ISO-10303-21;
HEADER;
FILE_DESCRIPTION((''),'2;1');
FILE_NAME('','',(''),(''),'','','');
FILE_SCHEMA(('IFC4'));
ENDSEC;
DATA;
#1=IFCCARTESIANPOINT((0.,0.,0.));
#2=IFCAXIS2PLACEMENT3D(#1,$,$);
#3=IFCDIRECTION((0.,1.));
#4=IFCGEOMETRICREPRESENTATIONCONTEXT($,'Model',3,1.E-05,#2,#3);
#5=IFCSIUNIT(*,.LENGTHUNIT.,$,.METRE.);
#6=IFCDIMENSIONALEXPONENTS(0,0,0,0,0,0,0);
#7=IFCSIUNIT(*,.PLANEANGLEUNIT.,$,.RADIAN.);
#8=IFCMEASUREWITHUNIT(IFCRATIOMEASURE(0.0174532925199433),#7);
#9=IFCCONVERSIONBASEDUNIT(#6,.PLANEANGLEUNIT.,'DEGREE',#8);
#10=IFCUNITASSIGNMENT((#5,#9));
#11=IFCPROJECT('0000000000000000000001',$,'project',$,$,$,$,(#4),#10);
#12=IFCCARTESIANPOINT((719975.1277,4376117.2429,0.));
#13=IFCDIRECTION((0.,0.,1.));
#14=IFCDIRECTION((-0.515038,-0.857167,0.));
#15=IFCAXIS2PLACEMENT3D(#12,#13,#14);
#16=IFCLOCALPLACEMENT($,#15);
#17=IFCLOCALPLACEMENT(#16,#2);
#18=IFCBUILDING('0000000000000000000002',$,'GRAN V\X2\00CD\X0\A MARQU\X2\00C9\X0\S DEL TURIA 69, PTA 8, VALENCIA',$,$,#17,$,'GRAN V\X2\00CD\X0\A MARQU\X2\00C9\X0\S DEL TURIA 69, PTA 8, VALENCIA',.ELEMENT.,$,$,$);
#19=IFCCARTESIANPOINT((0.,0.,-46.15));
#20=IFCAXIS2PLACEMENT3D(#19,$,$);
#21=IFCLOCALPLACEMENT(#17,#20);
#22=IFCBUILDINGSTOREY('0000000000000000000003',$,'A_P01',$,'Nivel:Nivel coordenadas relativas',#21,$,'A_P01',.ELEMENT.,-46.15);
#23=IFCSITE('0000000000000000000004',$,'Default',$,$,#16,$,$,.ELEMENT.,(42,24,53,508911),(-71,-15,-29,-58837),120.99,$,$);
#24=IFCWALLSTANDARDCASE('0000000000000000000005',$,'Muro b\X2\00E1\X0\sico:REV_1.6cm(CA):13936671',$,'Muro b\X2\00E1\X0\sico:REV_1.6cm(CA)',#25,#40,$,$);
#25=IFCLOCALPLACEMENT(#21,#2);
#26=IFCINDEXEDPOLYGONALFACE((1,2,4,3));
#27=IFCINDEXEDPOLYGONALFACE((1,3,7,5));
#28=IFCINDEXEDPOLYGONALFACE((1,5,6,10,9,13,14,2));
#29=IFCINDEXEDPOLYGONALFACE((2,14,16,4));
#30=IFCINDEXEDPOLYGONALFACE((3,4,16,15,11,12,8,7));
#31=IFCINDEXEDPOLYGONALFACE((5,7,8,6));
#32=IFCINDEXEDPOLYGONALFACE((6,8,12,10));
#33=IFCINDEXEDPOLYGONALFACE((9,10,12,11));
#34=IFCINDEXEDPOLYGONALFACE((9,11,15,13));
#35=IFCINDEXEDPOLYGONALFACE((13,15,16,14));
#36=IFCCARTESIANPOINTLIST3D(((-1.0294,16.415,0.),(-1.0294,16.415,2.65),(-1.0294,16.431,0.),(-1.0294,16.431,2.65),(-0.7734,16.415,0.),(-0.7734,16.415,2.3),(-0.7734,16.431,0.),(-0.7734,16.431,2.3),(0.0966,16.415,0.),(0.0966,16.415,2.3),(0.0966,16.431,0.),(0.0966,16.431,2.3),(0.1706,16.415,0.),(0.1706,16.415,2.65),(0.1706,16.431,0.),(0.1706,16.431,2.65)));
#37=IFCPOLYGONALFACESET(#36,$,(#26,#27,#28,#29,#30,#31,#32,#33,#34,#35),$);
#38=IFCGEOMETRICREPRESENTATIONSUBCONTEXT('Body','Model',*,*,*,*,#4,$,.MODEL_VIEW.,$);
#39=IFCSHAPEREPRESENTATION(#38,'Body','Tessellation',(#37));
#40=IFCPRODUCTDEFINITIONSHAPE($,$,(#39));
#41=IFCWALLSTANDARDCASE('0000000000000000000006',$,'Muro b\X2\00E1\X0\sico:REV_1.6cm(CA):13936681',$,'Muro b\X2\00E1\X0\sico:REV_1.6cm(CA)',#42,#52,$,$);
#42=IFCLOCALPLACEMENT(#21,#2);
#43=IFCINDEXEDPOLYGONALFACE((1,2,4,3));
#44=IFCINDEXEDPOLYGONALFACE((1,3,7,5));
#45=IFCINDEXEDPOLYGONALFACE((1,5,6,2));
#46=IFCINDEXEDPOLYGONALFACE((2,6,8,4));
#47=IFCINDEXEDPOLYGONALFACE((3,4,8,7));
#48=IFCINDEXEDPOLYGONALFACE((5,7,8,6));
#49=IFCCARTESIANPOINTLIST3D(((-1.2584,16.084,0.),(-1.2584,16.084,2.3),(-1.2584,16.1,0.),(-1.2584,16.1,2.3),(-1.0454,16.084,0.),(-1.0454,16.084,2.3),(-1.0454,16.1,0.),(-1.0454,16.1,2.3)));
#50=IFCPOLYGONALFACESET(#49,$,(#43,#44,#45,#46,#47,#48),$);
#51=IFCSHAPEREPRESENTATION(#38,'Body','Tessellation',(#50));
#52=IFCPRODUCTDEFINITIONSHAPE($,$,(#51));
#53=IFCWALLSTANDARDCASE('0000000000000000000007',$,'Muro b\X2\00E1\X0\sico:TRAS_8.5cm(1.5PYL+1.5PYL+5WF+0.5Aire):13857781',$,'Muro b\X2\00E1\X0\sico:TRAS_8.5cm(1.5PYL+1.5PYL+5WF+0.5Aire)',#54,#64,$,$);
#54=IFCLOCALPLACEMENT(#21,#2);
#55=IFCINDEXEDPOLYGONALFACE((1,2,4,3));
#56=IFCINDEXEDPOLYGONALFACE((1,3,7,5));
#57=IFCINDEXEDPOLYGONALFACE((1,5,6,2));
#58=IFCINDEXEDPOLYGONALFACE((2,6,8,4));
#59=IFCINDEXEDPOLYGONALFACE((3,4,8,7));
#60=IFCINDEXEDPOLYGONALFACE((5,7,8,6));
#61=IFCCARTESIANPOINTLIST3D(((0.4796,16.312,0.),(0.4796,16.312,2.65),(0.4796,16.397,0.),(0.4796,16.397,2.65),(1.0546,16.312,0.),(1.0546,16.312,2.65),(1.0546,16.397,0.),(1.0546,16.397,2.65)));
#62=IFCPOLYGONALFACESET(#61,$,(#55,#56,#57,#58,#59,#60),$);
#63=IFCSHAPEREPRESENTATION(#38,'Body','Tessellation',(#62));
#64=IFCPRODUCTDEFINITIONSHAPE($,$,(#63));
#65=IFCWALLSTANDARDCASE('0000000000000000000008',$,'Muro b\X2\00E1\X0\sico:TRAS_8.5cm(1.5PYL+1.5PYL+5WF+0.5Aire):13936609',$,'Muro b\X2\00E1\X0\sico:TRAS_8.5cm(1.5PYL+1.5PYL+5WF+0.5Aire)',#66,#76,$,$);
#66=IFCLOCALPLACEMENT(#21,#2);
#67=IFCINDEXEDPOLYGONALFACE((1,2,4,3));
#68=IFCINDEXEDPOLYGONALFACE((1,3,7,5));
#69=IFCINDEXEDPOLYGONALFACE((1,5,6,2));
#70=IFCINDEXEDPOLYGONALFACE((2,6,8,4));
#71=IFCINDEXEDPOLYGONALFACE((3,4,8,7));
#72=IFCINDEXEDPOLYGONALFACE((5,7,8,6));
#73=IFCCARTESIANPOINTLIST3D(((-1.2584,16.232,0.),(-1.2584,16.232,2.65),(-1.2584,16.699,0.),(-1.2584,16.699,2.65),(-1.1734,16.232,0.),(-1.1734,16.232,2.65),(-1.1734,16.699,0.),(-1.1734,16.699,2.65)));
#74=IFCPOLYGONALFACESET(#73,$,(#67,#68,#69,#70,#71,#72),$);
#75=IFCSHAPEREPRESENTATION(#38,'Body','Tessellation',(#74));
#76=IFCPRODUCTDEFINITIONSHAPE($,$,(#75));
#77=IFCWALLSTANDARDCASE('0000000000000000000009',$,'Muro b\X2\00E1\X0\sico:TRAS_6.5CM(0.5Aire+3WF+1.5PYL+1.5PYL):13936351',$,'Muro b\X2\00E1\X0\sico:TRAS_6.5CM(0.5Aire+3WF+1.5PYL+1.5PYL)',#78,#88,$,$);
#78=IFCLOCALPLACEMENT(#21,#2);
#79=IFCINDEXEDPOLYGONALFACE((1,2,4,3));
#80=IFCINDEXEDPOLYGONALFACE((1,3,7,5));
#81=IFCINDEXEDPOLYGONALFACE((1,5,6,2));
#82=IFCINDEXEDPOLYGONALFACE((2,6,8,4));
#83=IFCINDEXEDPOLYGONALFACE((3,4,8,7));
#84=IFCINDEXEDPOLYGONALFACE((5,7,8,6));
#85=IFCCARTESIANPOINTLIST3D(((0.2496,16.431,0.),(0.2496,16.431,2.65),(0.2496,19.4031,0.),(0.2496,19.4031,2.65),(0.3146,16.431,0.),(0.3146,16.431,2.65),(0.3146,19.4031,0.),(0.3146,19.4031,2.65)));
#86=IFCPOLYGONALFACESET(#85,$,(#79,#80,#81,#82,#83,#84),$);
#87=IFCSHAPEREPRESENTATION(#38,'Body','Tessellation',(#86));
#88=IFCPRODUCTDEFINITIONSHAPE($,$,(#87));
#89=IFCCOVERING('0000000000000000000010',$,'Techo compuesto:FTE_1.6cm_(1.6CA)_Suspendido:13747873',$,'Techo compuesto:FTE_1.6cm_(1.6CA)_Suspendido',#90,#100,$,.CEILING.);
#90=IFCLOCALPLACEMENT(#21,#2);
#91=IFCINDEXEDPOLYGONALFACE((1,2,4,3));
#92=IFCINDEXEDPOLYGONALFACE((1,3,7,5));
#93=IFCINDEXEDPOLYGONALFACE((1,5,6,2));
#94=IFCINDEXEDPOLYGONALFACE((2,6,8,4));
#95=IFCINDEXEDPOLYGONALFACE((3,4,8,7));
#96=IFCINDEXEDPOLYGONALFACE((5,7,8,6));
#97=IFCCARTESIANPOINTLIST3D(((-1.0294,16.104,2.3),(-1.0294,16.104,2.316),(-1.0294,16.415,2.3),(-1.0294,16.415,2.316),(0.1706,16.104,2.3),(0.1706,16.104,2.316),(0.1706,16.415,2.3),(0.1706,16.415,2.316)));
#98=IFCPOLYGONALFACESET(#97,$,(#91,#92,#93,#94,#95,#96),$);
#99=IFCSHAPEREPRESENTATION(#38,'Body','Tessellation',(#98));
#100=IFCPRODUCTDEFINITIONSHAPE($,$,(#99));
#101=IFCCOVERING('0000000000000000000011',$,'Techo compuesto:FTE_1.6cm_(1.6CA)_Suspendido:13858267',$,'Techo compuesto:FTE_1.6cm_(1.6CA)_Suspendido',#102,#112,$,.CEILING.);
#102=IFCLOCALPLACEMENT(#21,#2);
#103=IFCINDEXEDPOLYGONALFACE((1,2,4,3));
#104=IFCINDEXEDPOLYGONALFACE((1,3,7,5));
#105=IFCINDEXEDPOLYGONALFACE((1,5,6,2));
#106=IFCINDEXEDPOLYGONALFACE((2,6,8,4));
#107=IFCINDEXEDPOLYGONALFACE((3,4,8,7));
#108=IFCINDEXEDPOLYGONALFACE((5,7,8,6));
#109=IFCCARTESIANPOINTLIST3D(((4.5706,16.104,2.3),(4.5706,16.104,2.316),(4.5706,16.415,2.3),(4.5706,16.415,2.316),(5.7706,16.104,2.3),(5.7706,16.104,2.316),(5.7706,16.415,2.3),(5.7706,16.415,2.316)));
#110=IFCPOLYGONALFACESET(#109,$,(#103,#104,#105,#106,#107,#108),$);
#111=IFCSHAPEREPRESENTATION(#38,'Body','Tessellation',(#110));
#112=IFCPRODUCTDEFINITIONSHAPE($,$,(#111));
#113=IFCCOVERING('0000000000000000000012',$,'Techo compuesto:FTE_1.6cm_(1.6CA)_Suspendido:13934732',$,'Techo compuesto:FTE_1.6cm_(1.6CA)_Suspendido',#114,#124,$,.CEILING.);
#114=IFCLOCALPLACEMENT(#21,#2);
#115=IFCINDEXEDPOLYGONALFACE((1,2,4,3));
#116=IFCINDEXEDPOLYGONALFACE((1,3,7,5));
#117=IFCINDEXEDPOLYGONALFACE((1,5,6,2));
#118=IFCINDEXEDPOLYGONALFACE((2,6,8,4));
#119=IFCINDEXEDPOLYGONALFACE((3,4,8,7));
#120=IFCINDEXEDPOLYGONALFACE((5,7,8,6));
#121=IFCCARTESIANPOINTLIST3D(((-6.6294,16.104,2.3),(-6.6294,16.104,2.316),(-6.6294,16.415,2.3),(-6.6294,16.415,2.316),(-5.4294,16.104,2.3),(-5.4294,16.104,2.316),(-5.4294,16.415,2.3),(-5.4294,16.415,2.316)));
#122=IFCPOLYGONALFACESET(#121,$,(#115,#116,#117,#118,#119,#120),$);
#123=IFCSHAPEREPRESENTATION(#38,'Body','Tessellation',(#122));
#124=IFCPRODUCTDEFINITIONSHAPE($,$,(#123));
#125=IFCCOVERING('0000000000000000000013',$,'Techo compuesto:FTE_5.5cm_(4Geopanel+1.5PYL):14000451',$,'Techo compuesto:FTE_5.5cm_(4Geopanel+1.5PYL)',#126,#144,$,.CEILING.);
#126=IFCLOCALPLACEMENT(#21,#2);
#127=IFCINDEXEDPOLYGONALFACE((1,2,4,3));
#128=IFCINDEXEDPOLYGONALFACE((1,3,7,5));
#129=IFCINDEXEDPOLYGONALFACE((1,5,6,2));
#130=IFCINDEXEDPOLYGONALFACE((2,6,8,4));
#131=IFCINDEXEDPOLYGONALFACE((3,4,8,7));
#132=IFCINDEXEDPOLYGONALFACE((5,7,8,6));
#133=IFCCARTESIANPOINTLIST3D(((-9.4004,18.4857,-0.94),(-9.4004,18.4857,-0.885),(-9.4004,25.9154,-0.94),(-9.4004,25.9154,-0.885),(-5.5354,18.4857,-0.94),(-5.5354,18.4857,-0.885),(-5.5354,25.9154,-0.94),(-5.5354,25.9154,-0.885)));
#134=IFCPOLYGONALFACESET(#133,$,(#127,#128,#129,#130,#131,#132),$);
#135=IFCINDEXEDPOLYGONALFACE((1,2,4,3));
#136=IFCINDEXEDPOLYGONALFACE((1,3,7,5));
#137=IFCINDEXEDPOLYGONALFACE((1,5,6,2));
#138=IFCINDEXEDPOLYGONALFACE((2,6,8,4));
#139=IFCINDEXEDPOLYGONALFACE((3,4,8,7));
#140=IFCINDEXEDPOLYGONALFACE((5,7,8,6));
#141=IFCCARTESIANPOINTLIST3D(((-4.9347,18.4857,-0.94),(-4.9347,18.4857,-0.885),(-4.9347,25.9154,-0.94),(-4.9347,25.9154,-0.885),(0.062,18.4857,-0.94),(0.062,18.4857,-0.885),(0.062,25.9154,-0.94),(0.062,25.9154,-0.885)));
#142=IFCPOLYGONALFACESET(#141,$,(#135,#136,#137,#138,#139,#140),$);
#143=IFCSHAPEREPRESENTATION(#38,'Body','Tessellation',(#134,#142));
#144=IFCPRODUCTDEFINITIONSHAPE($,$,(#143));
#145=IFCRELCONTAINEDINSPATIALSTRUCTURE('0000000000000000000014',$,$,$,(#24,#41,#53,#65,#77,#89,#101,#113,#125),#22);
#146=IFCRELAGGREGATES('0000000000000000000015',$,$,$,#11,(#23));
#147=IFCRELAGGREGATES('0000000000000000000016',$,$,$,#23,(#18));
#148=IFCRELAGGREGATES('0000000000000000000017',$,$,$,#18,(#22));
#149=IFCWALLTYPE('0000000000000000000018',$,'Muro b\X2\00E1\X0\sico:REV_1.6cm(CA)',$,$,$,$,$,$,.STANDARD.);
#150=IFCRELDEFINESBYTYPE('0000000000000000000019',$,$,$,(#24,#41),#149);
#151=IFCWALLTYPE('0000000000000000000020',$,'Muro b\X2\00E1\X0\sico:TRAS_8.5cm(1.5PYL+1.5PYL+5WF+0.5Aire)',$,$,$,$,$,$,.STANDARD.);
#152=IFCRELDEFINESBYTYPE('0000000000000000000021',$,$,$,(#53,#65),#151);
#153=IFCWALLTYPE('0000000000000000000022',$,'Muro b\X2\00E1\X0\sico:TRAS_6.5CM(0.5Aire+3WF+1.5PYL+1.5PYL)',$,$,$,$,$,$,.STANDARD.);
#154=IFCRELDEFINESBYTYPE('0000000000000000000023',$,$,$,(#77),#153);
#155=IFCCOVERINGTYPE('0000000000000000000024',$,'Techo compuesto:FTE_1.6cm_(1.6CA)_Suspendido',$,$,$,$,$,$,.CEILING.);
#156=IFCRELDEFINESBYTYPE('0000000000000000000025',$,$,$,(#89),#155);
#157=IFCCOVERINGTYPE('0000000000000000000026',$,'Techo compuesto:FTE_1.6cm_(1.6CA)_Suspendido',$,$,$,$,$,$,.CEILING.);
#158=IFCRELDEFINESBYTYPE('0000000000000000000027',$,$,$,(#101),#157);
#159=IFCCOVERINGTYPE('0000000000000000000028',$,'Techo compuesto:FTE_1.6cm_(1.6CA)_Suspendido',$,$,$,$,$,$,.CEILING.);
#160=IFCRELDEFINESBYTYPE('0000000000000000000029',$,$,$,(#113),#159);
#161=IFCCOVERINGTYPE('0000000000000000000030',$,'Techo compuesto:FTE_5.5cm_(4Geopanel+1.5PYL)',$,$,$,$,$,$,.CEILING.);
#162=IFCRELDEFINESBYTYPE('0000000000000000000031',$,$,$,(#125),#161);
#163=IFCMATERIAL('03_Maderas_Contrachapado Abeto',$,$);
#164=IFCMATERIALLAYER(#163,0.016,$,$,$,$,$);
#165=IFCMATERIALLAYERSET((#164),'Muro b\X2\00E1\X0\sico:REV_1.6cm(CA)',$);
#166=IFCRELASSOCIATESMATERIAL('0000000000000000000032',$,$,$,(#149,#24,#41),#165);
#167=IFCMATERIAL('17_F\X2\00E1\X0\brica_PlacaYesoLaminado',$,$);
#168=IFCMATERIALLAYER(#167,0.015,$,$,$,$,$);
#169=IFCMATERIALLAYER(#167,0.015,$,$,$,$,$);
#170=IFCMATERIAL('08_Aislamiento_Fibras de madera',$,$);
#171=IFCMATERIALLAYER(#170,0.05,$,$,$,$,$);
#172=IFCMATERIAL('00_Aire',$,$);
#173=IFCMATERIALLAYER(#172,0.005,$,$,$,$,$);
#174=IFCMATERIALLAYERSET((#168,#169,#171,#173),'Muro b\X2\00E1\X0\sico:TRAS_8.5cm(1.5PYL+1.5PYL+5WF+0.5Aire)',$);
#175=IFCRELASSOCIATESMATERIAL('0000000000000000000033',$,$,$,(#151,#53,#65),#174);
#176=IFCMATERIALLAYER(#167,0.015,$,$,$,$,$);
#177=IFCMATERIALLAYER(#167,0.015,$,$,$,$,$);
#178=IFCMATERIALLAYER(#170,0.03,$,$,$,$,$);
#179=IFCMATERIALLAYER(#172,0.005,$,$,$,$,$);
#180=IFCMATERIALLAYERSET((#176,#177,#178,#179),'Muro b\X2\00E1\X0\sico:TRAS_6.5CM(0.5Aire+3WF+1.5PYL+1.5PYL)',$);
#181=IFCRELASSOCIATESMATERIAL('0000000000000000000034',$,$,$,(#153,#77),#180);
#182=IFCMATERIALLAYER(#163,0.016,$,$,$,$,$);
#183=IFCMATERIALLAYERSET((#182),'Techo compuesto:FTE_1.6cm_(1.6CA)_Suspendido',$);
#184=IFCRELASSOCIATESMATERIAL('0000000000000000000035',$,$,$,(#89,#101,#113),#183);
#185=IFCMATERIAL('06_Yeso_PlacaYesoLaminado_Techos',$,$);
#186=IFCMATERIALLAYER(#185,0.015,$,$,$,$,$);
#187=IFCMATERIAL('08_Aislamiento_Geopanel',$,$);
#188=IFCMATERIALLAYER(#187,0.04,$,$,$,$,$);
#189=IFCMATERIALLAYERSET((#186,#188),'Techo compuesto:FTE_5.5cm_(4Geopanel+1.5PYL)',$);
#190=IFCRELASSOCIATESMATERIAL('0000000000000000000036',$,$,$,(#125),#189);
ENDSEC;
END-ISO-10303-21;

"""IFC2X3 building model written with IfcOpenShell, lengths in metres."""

from ifc_helpers import new_model, entity, si_unit, converted_unit, direction, frame, frame_2d, origin, origin_2d_with_axis, place, context, subcontext, project, spatial, rectangle, extrude, material, layer, layer_set, layer_usage, type_object, element, save


model = new_model("IFC2X3")

# Units and contexts
model_context = context("Model", 3, precision=1e-05, world=origin(), true_north=direction((0.0, 1.0)))
body_context = subcontext(model_context, "Body", "Model", "MODEL_VIEW")
ifc_project = project(units=[si_unit("LENGTHUNIT", "METRE"), converted_unit("PLANEANGLEUNIT", "DEGREE", entity("IfcRatioMeasure", 0.0174532925199433), si_unit("PLANEANGLEUNIT", "RADIAN"), dimensions=[0, 0, 0, 0, 0, 0, 0])], contexts=[model_context])

# Site, building, storey
site_placement = place(None, frame((719975.1277, 4376117.2429, 0.0), z_axis=(0.0, 0.0, 1.0), x_axis=(-0.515038, -0.857167, 0.0)))
site = spatial("IfcSite", under=ifc_project, at=site_placement, Name="Default", CompositionType="ELEMENT", RefLatitude=(42, 24, 53, 508911), RefLongitude=(-71, -15, -29, -58837), RefElevation=120.99)
building_placement = place(site_placement, origin())
building = spatial("IfcBuilding", under=site, at=building_placement, Name="GRAN VÍA MARQUÉS DEL TURIA 69, PTA 8, VALENCIA", LongName="GRAN VÍA MARQUÉS DEL TURIA 69, PTA 8, VALENCIA", CompositionType="ELEMENT")
storey_placement = place(building_placement, frame((0.0, 0.0, -46.15)))
storey = spatial("IfcBuildingStorey", under=building, at=storey_placement, Name="A_P01", ObjectType="Nivel:Nivel coordenadas relativas", LongName="A_P01", CompositionType="ELEMENT", Elevation=-46.15)

# Shared definitions
ifc_material_1 = material(Name="08_Aislamiento_Fibras de madera")

# Shared definitions
ifc_material_2 = material(Name="03_Maderas_Contrachapado Abeto")
ifc_layer_1 = layer(ifc_material_2, 0.016)
ifc_layer_set_1 = layer_set([ifc_layer_1], Name="Muro básico:REV_1.6cm(CA)")
wall_type_1 = type_object("IfcWallType", Name="Muro básico:REV_1.6cm(CA)", PredefinedType="STANDARD", material=ifc_layer_set_1)

# Wall, opening
ifc_layer_usage_1 = layer_usage(ifc_layer_set_1, "AXIS2", "NEGATIVE", 0.008)
wall_1_placement = place(storey_placement, frame((-1.0294, 16.423, 0.0)))
wall_1 = element("IfcWallStandardCase", 1, at=wall_1_placement, inside=storey, type_object=wall_type_1, material=ifc_layer_usage_1, Name="Muro básico:REV_1.6cm(CA):13936671", ObjectType="Muro básico:REV_1.6cm(CA)", context=body_context, shape_type="SweptSolid", body=[
    extrude(rectangle(XDim=1.2, YDim=0.016, at=frame_2d((0.6, 0.0), x_axis=(-1.0, 0.0))), origin(), (0.0, 0.0, 1.0), 2.65),
])
opening_1_placement = place(wall_1_placement, origin())
element("IfcOpeningElement", 2, at=opening_1_placement, cuts=wall_1, ObjectType="Opening", context=body_context, shape_type="SweptSolid", body=[
    extrude(rectangle(XDim=2.3, YDim=0.87, at=origin_2d_with_axis()), frame((0.691, -0.008, 1.15), z_axis=(0.0, 1.0, 0.0), x_axis=(0.0, 0.0, -1.0)), (0.0, 0.0, 1.0), 0.016),
])

# Walls
ifc_layer_usage_2 = layer_usage(ifc_layer_set_1, "AXIS2", "NEGATIVE", 0.008)
wall_2_placement = place(storey_placement, frame((-1.2584, 16.092, 0.0)))
element("IfcWallStandardCase", 3, at=wall_2_placement, inside=storey, type_object=wall_type_1, material=ifc_layer_usage_2, Name="Muro básico:REV_1.6cm(CA):13936681", ObjectType="Muro básico:REV_1.6cm(CA)", context=body_context, shape_type="SweptSolid", body=[
    extrude(rectangle(XDim=0.213, YDim=0.016, at=frame_2d((0.1065, 0.0), x_axis=(-1.0, 0.0))), origin(), (0.0, 0.0, 1.0), 2.3),
])
ifc_material_3 = material(Name="17_Fábrica_PlacaYesoLaminado")
ifc_layer_2 = layer(ifc_material_3, 0.015)
ifc_layer_3 = layer(ifc_material_3, 0.015)
ifc_layer_4 = layer(ifc_material_1, 0.05)
ifc_material_4 = material(Name="00_Aire")
ifc_layer_5 = layer(ifc_material_4, 0.005)
ifc_layer_set_2 = layer_set([ifc_layer_2, ifc_layer_3, ifc_layer_4, ifc_layer_5], Name="Muro básico:TRAS_8.5cm(1.5PYL+1.5PYL+5WF+0.5Aire)")
ifc_layer_usage_3 = layer_usage(ifc_layer_set_2, "AXIS2", "NEGATIVE", 0.0425)
wall_type_2 = type_object("IfcWallType", Name="Muro básico:TRAS_8.5cm(1.5PYL+1.5PYL+5WF+0.5Aire)", PredefinedType="STANDARD", material=ifc_layer_set_2)
wall_3_placement = place(storey_placement, frame((0.4796, 16.3545, 0.0)))
element("IfcWallStandardCase", 4, at=wall_3_placement, inside=storey, type_object=wall_type_2, material=ifc_layer_usage_3, Name="Muro básico:TRAS_8.5cm(1.5PYL+1.5PYL+5WF+0.5Aire):13857781", ObjectType="Muro básico:TRAS_8.5cm(1.5PYL+1.5PYL+5WF+0.5Aire)", context=body_context, shape_type="SweptSolid", body=[
    extrude(rectangle(XDim=0.575, YDim=0.085, at=frame_2d((0.2875, 0.0), x_axis=(-1.0, 0.0))), origin(), (0.0, 0.0, 1.0), 2.65),
])
ifc_layer_usage_4 = layer_usage(ifc_layer_set_2, "AXIS2", "NEGATIVE", 0.0425)
wall_4_placement = place(storey_placement, frame((-1.2159, 16.232, 0.0), z_axis=(0.0, 0.0, 1.0), x_axis=(0.0, 1.0, 0.0)))
element("IfcWallStandardCase", 5, at=wall_4_placement, inside=storey, type_object=wall_type_2, material=ifc_layer_usage_4, Name="Muro básico:TRAS_8.5cm(1.5PYL+1.5PYL+5WF+0.5Aire):13936609", ObjectType="Muro básico:TRAS_8.5cm(1.5PYL+1.5PYL+5WF+0.5Aire)", context=body_context, shape_type="SweptSolid", body=[
    extrude(rectangle(XDim=0.467, YDim=0.085, at=frame_2d((0.2335, 0.0), x_axis=(-1.0, 0.0))), origin(), (0.0, 0.0, 1.0), 2.65),
])
ifc_layer_6 = layer(ifc_material_3, 0.015)
ifc_layer_7 = layer(ifc_material_3, 0.015)
ifc_layer_8 = layer(ifc_material_1, 0.03)
ifc_layer_9 = layer(ifc_material_4, 0.005)
ifc_layer_set_3 = layer_set([ifc_layer_6, ifc_layer_7, ifc_layer_8, ifc_layer_9], Name="Muro básico:TRAS_6.5CM(0.5Aire+3WF+1.5PYL+1.5PYL)")
ifc_layer_usage_5 = layer_usage(ifc_layer_set_3, "AXIS2", "NEGATIVE", 0.0325)
wall_type_3 = type_object("IfcWallType", Name="Muro básico:TRAS_6.5CM(0.5Aire+3WF+1.5PYL+1.5PYL)", PredefinedType="STANDARD", material=ifc_layer_set_3)
wall_5_placement = place(storey_placement, frame((0.2821, 16.431, 0.0), z_axis=(0.0, 0.0, 1.0), x_axis=(0.0, 1.0, 0.0)))
element("IfcWallStandardCase", 6, at=wall_5_placement, inside=storey, type_object=wall_type_3, material=ifc_layer_usage_5, Name="Muro básico:TRAS_6.5CM(0.5Aire+3WF+1.5PYL+1.5PYL):13936351", ObjectType="Muro básico:TRAS_6.5CM(0.5Aire+3WF+1.5PYL+1.5PYL)", context=body_context, shape_type="SweptSolid", body=[
    extrude(rectangle(XDim=2.972, YDim=0.065, at=frame_2d((1.486, 0.0), x_axis=(-1.0, 0.0))), origin(), (0.0, 0.0, 1.0), 2.65),
])

# Coverings
ifc_material_5 = material(Name="06_Yeso_PlacaYesoLaminado_Techos")
ifc_layer_10 = layer(ifc_material_2, 0.016)
ifc_layer_set_4 = layer_set([ifc_layer_10], Name="Techo compuesto:FTE_1.6cm_(1.6CA)_Suspendido")
ifc_layer_usage_6 = layer_usage(ifc_layer_set_4, "AXIS3", "POSITIVE", 0.0)
covering_type_1 = type_object("IfcCoveringType", Name="Techo compuesto:FTE_1.6cm_(1.6CA)_Suspendido", PredefinedType="CEILING")
covering_1_placement = place(storey_placement, origin())
element("IfcCovering", 7, at=covering_1_placement, inside=storey, type_object=covering_type_1, material=ifc_layer_usage_6, Name="Techo compuesto:FTE_1.6cm_(1.6CA)_Suspendido:13747873", ObjectType="Techo compuesto:FTE_1.6cm_(1.6CA)_Suspendido", PredefinedType="CEILING", context=body_context, shape_type="SweptSolid", body=[
    extrude(rectangle(XDim=1.2, YDim=0.311, at=frame_2d((0.0, 0.0), x_axis=(1.0, 0.0))), frame((-0.4294, 16.2595, 2.3)), (0.0, 0.0, 1.0), 0.016),
])
ifc_layer_usage_7 = layer_usage(ifc_layer_set_4, "AXIS3", "POSITIVE", 0.0)
covering_type_2 = type_object("IfcCoveringType", Name="Techo compuesto:FTE_1.6cm_(1.6CA)_Suspendido", PredefinedType="CEILING")
covering_2_placement = place(storey_placement, origin())
element("IfcCovering", 8, at=covering_2_placement, inside=storey, type_object=covering_type_2, material=ifc_layer_usage_7, Name="Techo compuesto:FTE_1.6cm_(1.6CA)_Suspendido:13858267", ObjectType="Techo compuesto:FTE_1.6cm_(1.6CA)_Suspendido", PredefinedType="CEILING", context=body_context, shape_type="SweptSolid", body=[
    extrude(rectangle(XDim=1.2, YDim=0.311, at=frame_2d((0.0, 0.0), x_axis=(1.0, 0.0))), frame((5.1706, 16.2595, 2.3)), (0.0, 0.0, 1.0), 0.016),
])
ifc_layer_usage_8 = layer_usage(ifc_layer_set_4, "AXIS3", "POSITIVE", 0.0)
covering_type_3 = type_object("IfcCoveringType", Name="Techo compuesto:FTE_1.6cm_(1.6CA)_Suspendido", PredefinedType="CEILING")
covering_3_placement = place(storey_placement, origin())
element("IfcCovering", 9, at=covering_3_placement, inside=storey, type_object=covering_type_3, material=ifc_layer_usage_8, Name="Techo compuesto:FTE_1.6cm_(1.6CA)_Suspendido:13934732", ObjectType="Techo compuesto:FTE_1.6cm_(1.6CA)_Suspendido", PredefinedType="CEILING", context=body_context, shape_type="SweptSolid", body=[
    extrude(rectangle(XDim=1.2, YDim=0.311, at=frame_2d((0.0, 0.0), x_axis=(1.0, 0.0))), frame((-6.0294, 16.2595, 2.3)), (0.0, 0.0, 1.0), 0.016),
])
ifc_layer_11 = layer(ifc_material_5, 0.015)
ifc_material_6 = material(Name="08_Aislamiento_Geopanel")
ifc_layer_12 = layer(ifc_material_6, 0.04)
ifc_layer_set_5 = layer_set([ifc_layer_11, ifc_layer_12], Name="Techo compuesto:FTE_5.5cm_(4Geopanel+1.5PYL)")
ifc_layer_usage_9 = layer_usage(ifc_layer_set_5, "AXIS3", "POSITIVE", 0.0)
covering_type_4 = type_object("IfcCoveringType", Name="Techo compuesto:FTE_5.5cm_(4Geopanel+1.5PYL)", PredefinedType="CEILING")
covering_4_placement = place(storey_placement, origin())
element("IfcCovering", 10, at=covering_4_placement, inside=storey, type_object=covering_type_4, material=ifc_layer_usage_9, Name="Techo compuesto:FTE_5.5cm_(4Geopanel+1.5PYL):14000451", ObjectType="Techo compuesto:FTE_5.5cm_(4Geopanel+1.5PYL)", PredefinedType="CEILING", context=body_context, shape_type="SweptSolid", body=[
    extrude(rectangle(XDim=7.4296, YDim=3.865, at=frame_2d((0.0, 0.0), x_axis=(1.0, 0.0))), frame((-7.4679, 22.2006, -0.94), z_axis=(0.0, 0.0, 1.0), x_axis=(0.0, -1.0, 0.0)), (0.0, 0.0, 1.0), 0.055),
    extrude(rectangle(XDim=7.4296, YDim=4.9967, at=frame_2d((0.0, 0.0), x_axis=(1.0, 0.0))), frame((-2.4363, 22.2006, -0.94), z_axis=(0.0, 0.0, 1.0), x_axis=(0.0, -1.0, 0.0)), (0.0, 0.0, 1.0), 0.055),
])

save(model, "model.ifc")
